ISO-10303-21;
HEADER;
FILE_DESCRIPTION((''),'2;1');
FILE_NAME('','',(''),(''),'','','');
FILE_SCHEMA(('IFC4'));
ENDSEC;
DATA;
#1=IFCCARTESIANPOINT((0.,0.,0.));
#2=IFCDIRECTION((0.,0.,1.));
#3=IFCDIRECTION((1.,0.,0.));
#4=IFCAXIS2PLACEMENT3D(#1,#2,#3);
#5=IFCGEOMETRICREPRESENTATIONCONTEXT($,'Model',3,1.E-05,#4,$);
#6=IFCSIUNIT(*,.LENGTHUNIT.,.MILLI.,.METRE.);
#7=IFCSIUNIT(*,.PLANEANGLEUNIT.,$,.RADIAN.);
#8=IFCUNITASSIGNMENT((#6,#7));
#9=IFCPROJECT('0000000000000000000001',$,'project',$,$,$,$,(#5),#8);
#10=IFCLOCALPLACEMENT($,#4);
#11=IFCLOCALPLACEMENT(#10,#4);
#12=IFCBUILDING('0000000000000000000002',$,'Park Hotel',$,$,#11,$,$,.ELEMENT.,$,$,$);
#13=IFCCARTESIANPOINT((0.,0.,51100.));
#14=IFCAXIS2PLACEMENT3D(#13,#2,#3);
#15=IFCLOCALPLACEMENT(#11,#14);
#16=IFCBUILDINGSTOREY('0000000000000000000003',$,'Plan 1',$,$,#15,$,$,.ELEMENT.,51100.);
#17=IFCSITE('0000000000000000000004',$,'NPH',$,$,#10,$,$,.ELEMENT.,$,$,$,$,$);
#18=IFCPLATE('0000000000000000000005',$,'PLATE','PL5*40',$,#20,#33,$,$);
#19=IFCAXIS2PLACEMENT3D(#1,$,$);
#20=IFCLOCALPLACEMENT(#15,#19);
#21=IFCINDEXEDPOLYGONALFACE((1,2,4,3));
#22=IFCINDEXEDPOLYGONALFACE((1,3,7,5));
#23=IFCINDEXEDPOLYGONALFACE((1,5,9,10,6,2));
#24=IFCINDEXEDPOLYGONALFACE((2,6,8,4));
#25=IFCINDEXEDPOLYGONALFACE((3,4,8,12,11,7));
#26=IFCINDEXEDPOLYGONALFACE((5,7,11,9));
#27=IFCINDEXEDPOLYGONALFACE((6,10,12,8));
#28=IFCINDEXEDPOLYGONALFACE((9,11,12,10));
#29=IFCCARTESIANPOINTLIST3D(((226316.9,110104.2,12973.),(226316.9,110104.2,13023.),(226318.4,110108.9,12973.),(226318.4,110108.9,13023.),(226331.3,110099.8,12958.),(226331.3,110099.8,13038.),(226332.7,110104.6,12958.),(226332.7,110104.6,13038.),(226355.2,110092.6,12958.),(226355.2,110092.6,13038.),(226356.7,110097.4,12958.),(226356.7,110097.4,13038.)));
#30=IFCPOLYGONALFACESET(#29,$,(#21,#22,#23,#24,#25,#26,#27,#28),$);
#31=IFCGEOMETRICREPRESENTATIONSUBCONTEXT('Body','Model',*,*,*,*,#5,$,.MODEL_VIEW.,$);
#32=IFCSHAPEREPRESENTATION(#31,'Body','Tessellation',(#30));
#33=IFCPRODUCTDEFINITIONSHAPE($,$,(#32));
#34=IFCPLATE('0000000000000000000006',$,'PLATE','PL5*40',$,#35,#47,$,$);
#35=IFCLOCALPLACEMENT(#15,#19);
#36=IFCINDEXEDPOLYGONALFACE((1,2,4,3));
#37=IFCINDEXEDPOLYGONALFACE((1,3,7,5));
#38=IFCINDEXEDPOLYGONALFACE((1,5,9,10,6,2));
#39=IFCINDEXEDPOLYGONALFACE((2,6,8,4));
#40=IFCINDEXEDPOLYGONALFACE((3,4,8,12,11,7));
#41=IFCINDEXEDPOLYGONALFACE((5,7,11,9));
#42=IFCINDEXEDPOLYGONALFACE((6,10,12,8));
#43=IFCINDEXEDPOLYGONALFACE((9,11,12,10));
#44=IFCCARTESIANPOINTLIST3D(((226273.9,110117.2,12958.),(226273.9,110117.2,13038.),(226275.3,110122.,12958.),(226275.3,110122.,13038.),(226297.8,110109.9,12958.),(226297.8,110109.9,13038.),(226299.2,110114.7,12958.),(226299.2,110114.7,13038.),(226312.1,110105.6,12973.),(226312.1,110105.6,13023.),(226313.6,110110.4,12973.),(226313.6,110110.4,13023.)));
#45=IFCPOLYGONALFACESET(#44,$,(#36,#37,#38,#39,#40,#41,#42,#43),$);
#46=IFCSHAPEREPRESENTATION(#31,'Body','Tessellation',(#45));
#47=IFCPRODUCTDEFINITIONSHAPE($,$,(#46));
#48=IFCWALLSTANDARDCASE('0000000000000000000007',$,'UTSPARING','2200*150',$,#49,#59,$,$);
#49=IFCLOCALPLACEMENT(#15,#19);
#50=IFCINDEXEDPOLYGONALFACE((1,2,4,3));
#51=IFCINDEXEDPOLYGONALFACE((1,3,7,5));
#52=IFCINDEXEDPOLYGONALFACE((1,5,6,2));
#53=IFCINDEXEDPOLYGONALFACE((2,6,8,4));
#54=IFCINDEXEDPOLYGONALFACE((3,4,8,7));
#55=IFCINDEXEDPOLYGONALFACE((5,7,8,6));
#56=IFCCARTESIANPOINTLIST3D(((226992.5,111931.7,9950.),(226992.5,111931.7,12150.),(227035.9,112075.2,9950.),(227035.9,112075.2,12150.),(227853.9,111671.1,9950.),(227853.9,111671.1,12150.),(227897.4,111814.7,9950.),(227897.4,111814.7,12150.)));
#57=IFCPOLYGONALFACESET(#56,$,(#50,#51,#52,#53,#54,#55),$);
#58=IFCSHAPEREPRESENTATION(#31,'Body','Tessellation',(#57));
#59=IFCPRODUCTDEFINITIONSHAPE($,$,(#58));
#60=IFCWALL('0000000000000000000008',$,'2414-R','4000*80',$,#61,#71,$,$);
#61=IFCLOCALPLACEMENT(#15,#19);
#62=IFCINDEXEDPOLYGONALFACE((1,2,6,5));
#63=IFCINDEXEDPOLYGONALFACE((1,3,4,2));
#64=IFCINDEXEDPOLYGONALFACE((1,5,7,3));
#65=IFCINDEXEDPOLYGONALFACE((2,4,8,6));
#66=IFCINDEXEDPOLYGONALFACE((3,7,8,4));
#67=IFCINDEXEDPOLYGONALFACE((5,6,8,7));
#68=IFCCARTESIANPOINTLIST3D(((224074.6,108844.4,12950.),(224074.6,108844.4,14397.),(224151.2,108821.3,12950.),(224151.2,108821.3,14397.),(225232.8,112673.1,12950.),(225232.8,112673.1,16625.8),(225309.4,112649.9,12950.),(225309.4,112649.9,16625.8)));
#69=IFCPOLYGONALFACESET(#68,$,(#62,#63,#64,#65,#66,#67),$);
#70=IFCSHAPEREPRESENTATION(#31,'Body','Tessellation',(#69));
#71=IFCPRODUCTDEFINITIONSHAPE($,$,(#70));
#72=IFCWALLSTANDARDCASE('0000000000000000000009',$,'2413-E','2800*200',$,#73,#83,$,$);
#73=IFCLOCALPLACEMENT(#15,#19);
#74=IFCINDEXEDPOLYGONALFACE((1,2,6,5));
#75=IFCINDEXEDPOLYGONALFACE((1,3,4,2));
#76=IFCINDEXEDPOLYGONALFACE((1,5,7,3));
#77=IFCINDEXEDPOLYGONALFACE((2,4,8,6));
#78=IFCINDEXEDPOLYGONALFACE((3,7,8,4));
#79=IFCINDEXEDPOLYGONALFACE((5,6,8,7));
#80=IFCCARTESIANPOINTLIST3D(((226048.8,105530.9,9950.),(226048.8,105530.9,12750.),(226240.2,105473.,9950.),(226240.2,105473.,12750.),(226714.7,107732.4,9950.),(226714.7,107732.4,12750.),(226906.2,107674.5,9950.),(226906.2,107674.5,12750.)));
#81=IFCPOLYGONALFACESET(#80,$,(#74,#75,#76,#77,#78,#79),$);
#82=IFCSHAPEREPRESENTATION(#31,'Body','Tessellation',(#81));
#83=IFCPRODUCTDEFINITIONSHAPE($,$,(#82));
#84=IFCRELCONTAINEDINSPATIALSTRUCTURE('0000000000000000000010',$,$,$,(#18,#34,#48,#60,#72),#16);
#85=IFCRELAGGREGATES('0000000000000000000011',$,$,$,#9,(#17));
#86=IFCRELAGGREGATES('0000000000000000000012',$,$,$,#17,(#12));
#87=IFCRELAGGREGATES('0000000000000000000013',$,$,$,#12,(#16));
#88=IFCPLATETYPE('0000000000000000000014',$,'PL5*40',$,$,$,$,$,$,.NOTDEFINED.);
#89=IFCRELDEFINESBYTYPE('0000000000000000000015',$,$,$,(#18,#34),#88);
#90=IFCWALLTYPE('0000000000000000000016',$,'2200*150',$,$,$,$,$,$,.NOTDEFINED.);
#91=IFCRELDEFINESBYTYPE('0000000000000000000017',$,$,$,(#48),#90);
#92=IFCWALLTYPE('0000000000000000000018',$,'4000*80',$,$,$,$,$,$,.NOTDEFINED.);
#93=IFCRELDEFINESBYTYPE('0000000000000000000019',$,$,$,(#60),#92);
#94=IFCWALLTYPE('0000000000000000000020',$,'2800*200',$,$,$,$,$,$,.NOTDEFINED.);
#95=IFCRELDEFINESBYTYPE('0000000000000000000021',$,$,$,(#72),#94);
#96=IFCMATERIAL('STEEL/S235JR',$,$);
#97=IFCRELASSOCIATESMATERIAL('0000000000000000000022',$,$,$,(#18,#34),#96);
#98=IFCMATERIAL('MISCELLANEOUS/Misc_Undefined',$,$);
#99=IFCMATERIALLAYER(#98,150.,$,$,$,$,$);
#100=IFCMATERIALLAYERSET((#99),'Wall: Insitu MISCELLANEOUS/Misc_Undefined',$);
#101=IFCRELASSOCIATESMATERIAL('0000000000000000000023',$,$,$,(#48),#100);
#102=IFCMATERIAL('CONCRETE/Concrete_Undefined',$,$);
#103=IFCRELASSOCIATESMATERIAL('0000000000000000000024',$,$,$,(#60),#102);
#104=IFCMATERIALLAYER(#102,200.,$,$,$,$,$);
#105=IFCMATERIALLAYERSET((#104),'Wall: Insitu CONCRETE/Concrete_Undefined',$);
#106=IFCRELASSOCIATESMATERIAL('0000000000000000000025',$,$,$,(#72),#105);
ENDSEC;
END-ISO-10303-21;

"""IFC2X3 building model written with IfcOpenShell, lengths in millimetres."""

from ifc_helpers import new_model, si_unit, frame, frame_2d, origin_with_axes, place, context, subcontext, project, spatial, polyline, rectangle, outline, extrude, clip, halfspace, material, layer, layer_set, layer_usage, type_object, element, save


model = new_model("IFC2X3")

# Units and contexts
model_context = context("Model", 3, precision=1e-05, world=origin_with_axes())
body_context = subcontext(model_context, "Body", "Model", "MODEL_VIEW")
ifc_project = project(units=[si_unit("LENGTHUNIT", "METRE", prefix="MILLI"), si_unit("PLANEANGLEUNIT", "RADIAN")], contexts=[model_context])

# Site, building, storey
site_placement = place(None, origin_with_axes())
site = spatial("IfcSite", under=ifc_project, at=site_placement, Name="NPH", CompositionType="ELEMENT")
building_placement = place(site_placement, origin_with_axes())
building = spatial("IfcBuilding", under=site, at=building_placement, Name="Park Hotel", CompositionType="ELEMENT")
storey_placement = place(building_placement, frame((0.0, 0.0, 51100.0), z_axis=(0.0, 0.0, 1.0), x_axis=(1.0, 0.0, 0.0)))
storey = spatial("IfcBuildingStorey", under=building, at=storey_placement, Name="Plan 1", CompositionType="ELEMENT", Elevation=51100.0)

# Plates
ifc_material_1 = material(Name="STEEL/S235JR")
plate_type = type_object("IfcPlateType", Name="PL5*40", PredefinedType="NOTDEFINED")
plate_1_placement = place(storey_placement, frame((226355.9, 110095.0, 12958.0), z_axis=(0.289538, 0.957167, 0.0), x_axis=(-0.957167, 0.289538, 0.0)))
element("IfcPlate", 1, at=plate_1_placement, inside=storey, type_object=plate_type, material=ifc_material_1, Name="PLATE", Description="PL5*40", context=body_context, shape_type="SweptSolid", body=[
    extrude(outline(polyline([(0.0, 0.0), (25.0, 0.0), (40.0, 15.0), (40.0, 65.0), (25.0, 80.0), (0.0, 80.0), (0.0, 0.0)])), frame((0.0, 0.0, -2.5), z_axis=(0.0, 0.0, 1.0), x_axis=(1.0, 0.0, 0.0)), (0.0, 0.0, 1.0), 5.0),
])
plate_2_placement = place(storey_placement, frame((226312.9, 110108.0, 12958.0), z_axis=(0.289538, 0.957167, 0.0), x_axis=(-0.957167, 0.289538, 0.0)))
element("IfcPlate", 2, at=plate_2_placement, inside=storey, type_object=plate_type, material=ifc_material_1, Name="PLATE", Description="PL5*40", context=body_context, shape_type="SweptSolid", body=[
    extrude(outline(polyline([(0.0, 15.0), (15.0, 0.0), (40.0, 0.0), (40.0, 80.0), (15.0, 80.0), (0.0, 65.0), (0.0, 15.0)])), frame((0.0, 0.0, -2.5), z_axis=(0.0, 0.0, 1.0), x_axis=(1.0, 0.0, 0.0)), (0.0, 0.0, 1.0), 5.0),
])

# Walls
ifc_material_2 = material(Name="MISCELLANEOUS/Misc_Undefined")
ifc_layer_1 = layer(ifc_material_2, 150.0)
ifc_layer_set_1 = layer_set([ifc_layer_1], Name="Wall: Insitu MISCELLANEOUS/Misc_Undefined")
ifc_layer_usage_1 = layer_usage(ifc_layer_set_1, "AXIS2", "POSITIVE", -75.0)
wall_type_1 = type_object("IfcWallType", Name="2200*150", PredefinedType="NOTDEFINED")
wall_1_placement = place(storey_placement, frame((227014.2, 112003.5, 9950.0), z_axis=(0.0, 0.0, 1.0), x_axis=(0.957166, -0.289541, 0.0)))
element("IfcWallStandardCase", 3, at=wall_1_placement, inside=storey, type_object=wall_type_1, material=ifc_layer_usage_1, Name="UTSPARING", Description="2200*150", context=body_context, shape_type="SweptSolid", body=[
    extrude(rectangle(XDim=900.0, YDim=150.0, at=frame_2d((0.0, 450.0), x_axis=(0.0, -1.0))), frame((0.0, 0.0, 0.0), z_axis=(0.0, 0.0, 1.0), x_axis=(0.0, -1.0, 0.0)), (0.0, 0.0, 1.0), 2200.0),
])
ifc_material_3 = material(Name="CONCRETE/Concrete_Undefined")
wall_type_2 = type_object("IfcWallType", Name="4000*80", PredefinedType="NOTDEFINED")
wall_2_placement = place(storey_placement, frame((225271.1, 112661.5, 13112.1), z_axis=(0.0, 0.0, 1.0), x_axis=(-0.289536, -0.957167, 0.0)))
element("IfcWall", 4, at=wall_2_placement, inside=storey, type_object=wall_type_2, material=ifc_material_3, Name="2414-R", Description="4000*80", context=body_context, shape_type="Clipping", body=[
    clip(extrude(rectangle(XDim=4000.0, YDim=80.0, at=frame_2d((0.0, 2000.0), x_axis=(0.0, -1.0))), frame((0.0, 0.0, -162.1), z_axis=(0.0, 0.0, 1.0), x_axis=(0.0, -1.0, 0.0)), (0.0, 0.0, 1.0), 4000.0), halfspace(frame((6596.8, -40.0, -162.1), z_axis=(0.486754, -0.000001, 0.873539), x_axis=(-0.873539, 0.0, 0.486754)), False)),
])
ifc_layer_2 = layer(ifc_material_3, 200.0)
ifc_layer_set_2 = layer_set([ifc_layer_2], Name="Wall: Insitu CONCRETE/Concrete_Undefined")
ifc_layer_usage_2 = layer_usage(ifc_layer_set_2, "AXIS2", "POSITIVE", -100.0)
wall_type_3 = type_object("IfcWallType", Name="2800*200", PredefinedType="NOTDEFINED")
wall_3_placement = place(storey_placement, frame((226144.5, 105501.9, 9950.0), z_axis=(0.0, 0.0, 1.0), x_axis=(0.289536, 0.957167, 0.0)))
element("IfcWallStandardCase", 5, at=wall_3_placement, inside=storey, type_object=wall_type_3, material=ifc_layer_usage_2, Name="2413-E", Description="2800*200", context=body_context, shape_type="SweptSolid", body=[
    extrude(rectangle(XDim=2300.0, YDim=200.0, at=frame_2d((0.0, 1150.0), x_axis=(0.0, -1.0))), frame((0.0, 0.0, 0.0), z_axis=(0.0, 0.0, 1.0), x_axis=(0.0, -1.0, 0.0)), (0.0, 0.0, 1.0), 2800.0),
])

save(model, "model.ifc")
